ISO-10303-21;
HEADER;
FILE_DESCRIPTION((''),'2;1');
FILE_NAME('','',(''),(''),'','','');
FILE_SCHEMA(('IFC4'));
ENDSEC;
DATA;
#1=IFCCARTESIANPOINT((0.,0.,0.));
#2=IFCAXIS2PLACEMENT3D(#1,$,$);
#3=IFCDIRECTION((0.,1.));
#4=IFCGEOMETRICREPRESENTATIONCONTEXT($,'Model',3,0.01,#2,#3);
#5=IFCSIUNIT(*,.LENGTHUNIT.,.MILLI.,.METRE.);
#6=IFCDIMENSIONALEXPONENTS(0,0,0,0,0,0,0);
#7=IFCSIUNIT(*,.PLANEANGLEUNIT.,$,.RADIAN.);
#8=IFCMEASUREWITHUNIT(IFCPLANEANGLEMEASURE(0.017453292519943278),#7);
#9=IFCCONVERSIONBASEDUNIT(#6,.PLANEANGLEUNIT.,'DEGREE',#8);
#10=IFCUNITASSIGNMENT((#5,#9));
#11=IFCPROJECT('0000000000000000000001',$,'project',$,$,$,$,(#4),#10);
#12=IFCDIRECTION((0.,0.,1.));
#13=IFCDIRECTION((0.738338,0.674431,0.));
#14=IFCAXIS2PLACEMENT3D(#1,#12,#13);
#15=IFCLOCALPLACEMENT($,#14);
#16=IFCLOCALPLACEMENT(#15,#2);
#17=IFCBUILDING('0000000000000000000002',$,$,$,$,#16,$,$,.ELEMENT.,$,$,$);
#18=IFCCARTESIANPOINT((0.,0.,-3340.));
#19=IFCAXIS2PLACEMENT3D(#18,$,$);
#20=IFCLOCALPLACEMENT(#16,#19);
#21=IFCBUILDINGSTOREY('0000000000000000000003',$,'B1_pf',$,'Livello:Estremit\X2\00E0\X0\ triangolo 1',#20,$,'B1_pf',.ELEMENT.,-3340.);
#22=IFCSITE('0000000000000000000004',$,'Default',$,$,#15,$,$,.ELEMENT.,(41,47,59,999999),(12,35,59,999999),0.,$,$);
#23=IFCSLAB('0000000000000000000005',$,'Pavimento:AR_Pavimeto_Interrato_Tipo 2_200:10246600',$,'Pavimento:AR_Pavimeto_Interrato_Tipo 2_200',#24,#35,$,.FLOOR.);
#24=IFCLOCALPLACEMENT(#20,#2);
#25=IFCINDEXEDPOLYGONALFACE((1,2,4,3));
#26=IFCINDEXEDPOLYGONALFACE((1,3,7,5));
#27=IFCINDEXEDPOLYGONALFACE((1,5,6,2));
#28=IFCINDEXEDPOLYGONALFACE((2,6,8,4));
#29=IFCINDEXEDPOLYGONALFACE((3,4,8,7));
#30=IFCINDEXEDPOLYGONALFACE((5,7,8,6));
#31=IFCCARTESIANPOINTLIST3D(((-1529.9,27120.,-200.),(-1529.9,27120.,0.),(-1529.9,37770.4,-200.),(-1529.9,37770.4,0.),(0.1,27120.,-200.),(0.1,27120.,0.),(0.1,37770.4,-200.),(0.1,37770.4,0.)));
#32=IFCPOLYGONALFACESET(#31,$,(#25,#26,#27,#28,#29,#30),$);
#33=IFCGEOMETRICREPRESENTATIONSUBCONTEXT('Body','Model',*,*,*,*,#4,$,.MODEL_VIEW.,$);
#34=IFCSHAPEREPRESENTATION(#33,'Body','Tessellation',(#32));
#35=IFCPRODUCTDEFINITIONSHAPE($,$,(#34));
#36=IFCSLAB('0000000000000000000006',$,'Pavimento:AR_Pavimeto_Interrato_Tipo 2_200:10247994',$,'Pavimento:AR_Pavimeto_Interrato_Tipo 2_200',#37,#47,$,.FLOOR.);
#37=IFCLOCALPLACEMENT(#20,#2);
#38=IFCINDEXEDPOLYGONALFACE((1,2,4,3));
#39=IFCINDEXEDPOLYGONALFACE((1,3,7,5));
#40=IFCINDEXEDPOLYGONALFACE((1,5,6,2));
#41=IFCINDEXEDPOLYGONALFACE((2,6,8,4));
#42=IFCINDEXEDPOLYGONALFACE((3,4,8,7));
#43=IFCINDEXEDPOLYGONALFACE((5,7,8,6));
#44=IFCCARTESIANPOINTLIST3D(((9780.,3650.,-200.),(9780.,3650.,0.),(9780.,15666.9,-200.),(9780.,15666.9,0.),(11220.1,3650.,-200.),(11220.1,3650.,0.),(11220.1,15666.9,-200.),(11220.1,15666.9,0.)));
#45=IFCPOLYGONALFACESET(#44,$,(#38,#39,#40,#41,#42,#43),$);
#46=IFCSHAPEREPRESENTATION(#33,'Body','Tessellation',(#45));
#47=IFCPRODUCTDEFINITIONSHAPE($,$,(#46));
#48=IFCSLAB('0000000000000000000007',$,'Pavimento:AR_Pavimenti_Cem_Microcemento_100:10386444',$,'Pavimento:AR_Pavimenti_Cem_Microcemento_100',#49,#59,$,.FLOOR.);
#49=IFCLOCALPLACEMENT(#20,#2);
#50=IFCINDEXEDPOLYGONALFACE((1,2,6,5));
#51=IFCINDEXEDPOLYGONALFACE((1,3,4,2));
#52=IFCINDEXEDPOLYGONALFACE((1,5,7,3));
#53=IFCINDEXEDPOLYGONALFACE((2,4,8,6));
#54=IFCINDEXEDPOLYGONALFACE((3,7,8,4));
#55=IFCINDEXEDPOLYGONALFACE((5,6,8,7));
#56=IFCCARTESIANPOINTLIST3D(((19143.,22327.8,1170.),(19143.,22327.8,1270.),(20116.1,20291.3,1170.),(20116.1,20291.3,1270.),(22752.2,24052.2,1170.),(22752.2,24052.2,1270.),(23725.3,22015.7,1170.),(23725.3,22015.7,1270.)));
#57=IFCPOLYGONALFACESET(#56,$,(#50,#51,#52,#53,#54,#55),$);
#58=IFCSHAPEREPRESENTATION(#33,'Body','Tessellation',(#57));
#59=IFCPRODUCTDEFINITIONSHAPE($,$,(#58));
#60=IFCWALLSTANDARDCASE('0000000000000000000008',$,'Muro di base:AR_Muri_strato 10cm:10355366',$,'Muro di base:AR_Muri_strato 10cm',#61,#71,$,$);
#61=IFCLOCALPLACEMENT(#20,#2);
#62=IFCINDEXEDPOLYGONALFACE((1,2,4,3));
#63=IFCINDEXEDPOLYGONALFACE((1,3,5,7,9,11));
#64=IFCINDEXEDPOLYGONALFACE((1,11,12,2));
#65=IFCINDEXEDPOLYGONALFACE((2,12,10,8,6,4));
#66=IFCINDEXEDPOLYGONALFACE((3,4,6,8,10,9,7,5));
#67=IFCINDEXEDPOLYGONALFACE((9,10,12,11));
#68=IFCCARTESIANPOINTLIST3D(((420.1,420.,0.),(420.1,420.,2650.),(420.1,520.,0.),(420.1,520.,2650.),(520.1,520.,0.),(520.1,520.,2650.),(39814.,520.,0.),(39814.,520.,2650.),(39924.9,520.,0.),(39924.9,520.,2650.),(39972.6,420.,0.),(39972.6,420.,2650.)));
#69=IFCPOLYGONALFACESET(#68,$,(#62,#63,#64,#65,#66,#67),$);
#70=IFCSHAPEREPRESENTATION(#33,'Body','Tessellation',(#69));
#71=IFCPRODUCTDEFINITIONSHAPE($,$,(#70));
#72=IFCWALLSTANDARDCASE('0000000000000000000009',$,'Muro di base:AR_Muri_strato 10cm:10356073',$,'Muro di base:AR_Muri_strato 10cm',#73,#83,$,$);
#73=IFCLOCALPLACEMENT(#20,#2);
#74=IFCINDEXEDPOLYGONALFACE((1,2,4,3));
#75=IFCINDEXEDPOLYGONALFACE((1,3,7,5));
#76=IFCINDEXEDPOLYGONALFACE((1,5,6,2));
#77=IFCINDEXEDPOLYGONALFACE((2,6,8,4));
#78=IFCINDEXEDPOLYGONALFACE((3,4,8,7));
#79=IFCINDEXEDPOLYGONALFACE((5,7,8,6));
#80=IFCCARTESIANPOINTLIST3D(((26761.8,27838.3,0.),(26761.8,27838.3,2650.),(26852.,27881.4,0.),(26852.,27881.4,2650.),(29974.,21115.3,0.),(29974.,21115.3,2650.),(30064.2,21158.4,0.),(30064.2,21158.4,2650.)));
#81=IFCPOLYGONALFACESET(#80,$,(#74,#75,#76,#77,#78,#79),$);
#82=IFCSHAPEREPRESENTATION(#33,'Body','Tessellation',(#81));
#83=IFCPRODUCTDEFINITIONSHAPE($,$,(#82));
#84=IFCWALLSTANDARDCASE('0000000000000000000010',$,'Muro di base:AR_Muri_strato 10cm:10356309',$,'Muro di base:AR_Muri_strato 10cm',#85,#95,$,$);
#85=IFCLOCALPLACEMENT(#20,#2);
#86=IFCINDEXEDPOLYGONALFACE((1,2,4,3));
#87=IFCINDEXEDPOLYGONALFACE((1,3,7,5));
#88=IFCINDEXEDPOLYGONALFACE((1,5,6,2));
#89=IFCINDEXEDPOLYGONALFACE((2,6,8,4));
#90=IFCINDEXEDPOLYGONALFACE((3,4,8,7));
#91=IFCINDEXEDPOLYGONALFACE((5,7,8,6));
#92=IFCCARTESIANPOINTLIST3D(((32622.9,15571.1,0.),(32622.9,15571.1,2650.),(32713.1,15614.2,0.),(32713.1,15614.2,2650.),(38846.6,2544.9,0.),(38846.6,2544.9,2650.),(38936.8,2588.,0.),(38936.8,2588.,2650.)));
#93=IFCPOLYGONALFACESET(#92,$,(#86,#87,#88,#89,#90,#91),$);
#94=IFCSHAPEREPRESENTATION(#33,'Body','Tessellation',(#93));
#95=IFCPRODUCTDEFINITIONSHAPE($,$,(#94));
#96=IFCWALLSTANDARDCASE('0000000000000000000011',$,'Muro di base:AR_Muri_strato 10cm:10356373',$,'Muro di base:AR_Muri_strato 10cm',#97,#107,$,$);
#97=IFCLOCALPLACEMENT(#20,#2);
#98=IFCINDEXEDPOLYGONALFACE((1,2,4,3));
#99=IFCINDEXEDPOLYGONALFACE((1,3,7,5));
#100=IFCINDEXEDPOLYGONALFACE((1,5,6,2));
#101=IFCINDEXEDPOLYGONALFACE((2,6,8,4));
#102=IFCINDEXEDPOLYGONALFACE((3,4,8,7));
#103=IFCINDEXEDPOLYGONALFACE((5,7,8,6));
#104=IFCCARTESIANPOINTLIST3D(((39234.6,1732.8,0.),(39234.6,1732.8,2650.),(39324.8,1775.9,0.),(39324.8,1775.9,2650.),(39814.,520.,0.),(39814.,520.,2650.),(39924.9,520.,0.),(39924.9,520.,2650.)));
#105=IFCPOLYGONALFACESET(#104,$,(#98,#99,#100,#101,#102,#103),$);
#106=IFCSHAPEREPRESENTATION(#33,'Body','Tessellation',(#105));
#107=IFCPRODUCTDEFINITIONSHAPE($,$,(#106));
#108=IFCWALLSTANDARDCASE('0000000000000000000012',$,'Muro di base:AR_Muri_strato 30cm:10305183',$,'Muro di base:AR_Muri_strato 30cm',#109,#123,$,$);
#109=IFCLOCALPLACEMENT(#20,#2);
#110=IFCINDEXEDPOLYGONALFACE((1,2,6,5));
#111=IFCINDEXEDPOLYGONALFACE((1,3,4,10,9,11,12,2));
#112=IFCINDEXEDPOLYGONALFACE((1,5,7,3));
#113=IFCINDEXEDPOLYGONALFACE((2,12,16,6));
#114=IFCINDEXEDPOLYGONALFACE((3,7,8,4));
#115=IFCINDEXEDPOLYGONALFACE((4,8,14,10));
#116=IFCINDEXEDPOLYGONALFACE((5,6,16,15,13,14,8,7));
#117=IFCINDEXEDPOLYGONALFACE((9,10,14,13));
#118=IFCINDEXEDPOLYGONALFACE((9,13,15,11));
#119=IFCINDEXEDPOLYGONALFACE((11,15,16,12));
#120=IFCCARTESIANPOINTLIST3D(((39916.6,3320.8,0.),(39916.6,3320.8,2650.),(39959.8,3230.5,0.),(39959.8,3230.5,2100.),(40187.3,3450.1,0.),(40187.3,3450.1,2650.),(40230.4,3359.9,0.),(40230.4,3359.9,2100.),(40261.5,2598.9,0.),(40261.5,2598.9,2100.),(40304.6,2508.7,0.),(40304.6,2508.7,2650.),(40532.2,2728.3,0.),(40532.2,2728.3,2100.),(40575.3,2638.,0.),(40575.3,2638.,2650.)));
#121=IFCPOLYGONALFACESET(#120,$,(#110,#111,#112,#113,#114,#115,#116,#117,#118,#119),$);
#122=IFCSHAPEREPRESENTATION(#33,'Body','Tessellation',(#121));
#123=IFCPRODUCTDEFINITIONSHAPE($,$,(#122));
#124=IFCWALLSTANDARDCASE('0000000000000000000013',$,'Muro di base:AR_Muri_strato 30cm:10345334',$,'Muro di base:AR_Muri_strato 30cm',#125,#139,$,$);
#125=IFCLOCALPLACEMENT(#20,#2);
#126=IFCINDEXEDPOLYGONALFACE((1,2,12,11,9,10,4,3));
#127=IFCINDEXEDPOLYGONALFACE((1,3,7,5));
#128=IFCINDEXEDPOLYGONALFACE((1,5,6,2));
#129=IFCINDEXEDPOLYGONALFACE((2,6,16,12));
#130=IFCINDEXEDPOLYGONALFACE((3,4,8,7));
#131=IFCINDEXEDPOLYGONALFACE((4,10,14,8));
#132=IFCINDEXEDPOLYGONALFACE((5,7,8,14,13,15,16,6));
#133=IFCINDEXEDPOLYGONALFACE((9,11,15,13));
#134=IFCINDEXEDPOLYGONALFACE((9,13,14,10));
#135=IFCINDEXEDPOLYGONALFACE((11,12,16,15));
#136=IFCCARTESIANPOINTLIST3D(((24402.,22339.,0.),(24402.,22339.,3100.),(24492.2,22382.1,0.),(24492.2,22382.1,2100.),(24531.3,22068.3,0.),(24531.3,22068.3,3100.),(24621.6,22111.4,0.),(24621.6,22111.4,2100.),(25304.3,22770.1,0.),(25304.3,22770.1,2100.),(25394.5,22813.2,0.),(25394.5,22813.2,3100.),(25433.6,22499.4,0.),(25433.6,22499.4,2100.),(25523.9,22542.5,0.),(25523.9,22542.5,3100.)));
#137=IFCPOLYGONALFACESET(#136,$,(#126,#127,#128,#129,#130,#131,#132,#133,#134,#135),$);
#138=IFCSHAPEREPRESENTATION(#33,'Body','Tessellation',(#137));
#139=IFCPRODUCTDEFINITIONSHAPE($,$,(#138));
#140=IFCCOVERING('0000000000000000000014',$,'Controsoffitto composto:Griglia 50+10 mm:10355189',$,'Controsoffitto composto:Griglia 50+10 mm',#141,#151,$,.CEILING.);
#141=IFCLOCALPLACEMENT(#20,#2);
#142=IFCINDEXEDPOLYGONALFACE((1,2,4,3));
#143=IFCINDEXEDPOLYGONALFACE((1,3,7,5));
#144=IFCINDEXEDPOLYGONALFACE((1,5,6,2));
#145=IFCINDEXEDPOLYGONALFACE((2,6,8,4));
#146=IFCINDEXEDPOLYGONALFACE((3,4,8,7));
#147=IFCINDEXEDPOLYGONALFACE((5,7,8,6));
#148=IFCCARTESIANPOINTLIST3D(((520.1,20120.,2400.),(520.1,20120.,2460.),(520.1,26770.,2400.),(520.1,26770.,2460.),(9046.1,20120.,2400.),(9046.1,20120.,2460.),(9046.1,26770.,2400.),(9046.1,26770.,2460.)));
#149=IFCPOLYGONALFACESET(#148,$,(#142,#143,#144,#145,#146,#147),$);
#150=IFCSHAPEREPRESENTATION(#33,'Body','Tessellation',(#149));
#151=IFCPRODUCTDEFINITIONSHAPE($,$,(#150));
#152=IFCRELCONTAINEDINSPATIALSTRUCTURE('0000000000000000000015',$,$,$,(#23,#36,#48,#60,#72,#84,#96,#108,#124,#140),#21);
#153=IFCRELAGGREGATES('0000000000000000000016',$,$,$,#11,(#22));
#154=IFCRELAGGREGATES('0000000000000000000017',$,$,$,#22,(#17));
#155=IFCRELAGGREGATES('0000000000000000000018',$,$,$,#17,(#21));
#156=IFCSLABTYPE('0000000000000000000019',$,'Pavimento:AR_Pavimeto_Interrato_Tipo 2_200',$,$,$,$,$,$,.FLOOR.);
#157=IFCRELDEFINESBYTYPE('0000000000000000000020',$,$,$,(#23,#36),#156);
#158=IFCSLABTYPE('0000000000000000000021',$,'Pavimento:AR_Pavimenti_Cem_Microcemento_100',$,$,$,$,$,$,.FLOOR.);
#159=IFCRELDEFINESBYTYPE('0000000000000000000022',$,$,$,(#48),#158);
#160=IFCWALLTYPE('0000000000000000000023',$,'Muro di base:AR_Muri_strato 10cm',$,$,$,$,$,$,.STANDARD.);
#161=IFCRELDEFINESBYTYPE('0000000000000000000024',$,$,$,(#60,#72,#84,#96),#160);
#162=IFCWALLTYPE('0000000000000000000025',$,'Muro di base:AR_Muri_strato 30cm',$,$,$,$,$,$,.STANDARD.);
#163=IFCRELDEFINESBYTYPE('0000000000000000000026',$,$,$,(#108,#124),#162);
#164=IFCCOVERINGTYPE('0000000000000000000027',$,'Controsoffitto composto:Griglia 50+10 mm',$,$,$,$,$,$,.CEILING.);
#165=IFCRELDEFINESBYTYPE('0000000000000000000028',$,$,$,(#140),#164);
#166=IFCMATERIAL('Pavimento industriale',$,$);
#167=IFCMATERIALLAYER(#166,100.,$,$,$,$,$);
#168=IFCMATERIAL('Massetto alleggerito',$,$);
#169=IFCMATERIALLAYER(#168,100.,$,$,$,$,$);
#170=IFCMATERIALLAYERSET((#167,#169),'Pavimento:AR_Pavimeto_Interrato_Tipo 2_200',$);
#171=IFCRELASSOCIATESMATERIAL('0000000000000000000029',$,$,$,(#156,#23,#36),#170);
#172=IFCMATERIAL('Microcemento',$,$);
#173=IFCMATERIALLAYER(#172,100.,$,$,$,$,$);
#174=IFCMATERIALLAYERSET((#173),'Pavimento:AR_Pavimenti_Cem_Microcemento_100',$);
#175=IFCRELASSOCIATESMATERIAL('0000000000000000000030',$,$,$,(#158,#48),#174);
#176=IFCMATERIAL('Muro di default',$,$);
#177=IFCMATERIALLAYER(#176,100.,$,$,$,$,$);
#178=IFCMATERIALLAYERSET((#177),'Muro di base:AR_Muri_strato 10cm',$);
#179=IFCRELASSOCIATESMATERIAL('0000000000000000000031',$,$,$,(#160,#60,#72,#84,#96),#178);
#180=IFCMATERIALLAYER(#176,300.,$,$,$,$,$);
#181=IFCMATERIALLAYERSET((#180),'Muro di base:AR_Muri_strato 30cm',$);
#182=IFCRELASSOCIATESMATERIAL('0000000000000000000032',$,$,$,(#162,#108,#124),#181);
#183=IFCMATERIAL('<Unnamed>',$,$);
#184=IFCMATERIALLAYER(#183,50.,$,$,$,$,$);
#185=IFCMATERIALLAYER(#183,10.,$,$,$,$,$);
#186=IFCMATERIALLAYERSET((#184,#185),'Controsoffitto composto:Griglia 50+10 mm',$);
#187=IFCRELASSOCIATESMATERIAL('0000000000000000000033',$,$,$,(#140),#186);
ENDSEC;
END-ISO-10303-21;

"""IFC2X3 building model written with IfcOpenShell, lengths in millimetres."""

from ifc_helpers import new_model, entity, si_unit, converted_unit, direction, frame, frame_2d, origin, origin_2d_with_axis, place, context, subcontext, project, spatial, polyline, rectangle, outline, extrude, material, layer, layer_set, layer_usage, type_object, element, save


model = new_model("IFC2X3")

# Units and contexts
model_context = context("Model", 3, precision=0.01, world=origin(), true_north=direction((0.0, 1.0)))
body_context = subcontext(model_context, "Body", "Model", "MODEL_VIEW")
ifc_project = project(units=[si_unit("LENGTHUNIT", "METRE", prefix="MILLI"), converted_unit("PLANEANGLEUNIT", "DEGREE", entity("IfcPlaneAngleMeasure", 0.017453292519943278), si_unit("PLANEANGLEUNIT", "RADIAN"), dimensions=[0, 0, 0, 0, 0, 0, 0])], contexts=[model_context])

# Site, building, storey
site_placement = place(None, frame((0.0, 0.0, 0.0), z_axis=(0.0, 0.0, 1.0), x_axis=(0.738338, 0.674431, 0.0)))
site = spatial("IfcSite", under=ifc_project, at=site_placement, Name="Default", CompositionType="ELEMENT", RefLatitude=(41, 47, 59, 999999), RefLongitude=(12, 35, 59, 999999), RefElevation=0.0)
building_placement = place(site_placement, origin())
building = spatial("IfcBuilding", under=site, at=building_placement, CompositionType="ELEMENT")
storey_placement = place(building_placement, frame((0.0, 0.0, -3340.0)))
storey = spatial("IfcBuildingStorey", under=building, at=storey_placement, Name="B1_pf", ObjectType="Livello:Estremità triangolo 1", LongName="B1_pf", CompositionType="ELEMENT", Elevation=-3340.0)

# Slabs
ifc_material_1 = material(Name="Pavimento industriale")
ifc_layer_1 = layer(ifc_material_1, 100.0)
ifc_material_2 = material(Name="Massetto alleggerito")
ifc_layer_2 = layer(ifc_material_2, 100.0)
ifc_layer_set_1 = layer_set([ifc_layer_1, ifc_layer_2], Name="Pavimento:AR_Pavimeto_Interrato_Tipo 2_200")
slab_type_1 = type_object("IfcSlabType", Name="Pavimento:AR_Pavimeto_Interrato_Tipo 2_200", PredefinedType="FLOOR", material=ifc_layer_set_1)
ifc_layer_usage_1 = layer_usage(ifc_layer_set_1, "AXIS3", "POSITIVE", 0.0)
slab_1_placement = place(storey_placement, origin())
element("IfcSlab", 1, at=slab_1_placement, inside=storey, type_object=slab_type_1, material=ifc_layer_usage_1, Name="Pavimento:AR_Pavimeto_Interrato_Tipo 2_200:10246600", ObjectType="Pavimento:AR_Pavimeto_Interrato_Tipo 2_200", PredefinedType="FLOOR", context=body_context, shape_type="SweptSolid", body=[
    extrude(rectangle(XDim=10650.3, YDim=1530.0, at=origin_2d_with_axis()), frame((-764.9, 32445.2, 0.0), z_axis=(0.0, 0.0, -1.0), x_axis=(0.0, 1.0, 0.0)), (0.0, 0.0, 1.0), 200.0),
])
ifc_layer_usage_2 = layer_usage(ifc_layer_set_1, "AXIS3", "POSITIVE", 0.0)
slab_2_placement = place(storey_placement, origin())
element("IfcSlab", 2, at=slab_2_placement, inside=storey, type_object=slab_type_1, material=ifc_layer_usage_2, Name="Pavimento:AR_Pavimeto_Interrato_Tipo 2_200:10247994", ObjectType="Pavimento:AR_Pavimeto_Interrato_Tipo 2_200", PredefinedType="FLOOR", context=body_context, shape_type="SweptSolid", body=[
    extrude(rectangle(XDim=12016.9, YDim=1440.0, at=frame_2d((0.0, 0.0), x_axis=(1.0, 0.0))), frame((10500.1, 9658.5, 0.0), z_axis=(0.0, 0.0, -1.0), x_axis=(0.0, 1.0, 0.0)), (0.0, 0.0, 1.0), 200.0),
])
ifc_material_3 = material(Name="Microcemento")
ifc_layer_3 = layer(ifc_material_3, 100.0)
ifc_layer_set_2 = layer_set([ifc_layer_3], Name="Pavimento:AR_Pavimenti_Cem_Microcemento_100")
ifc_layer_usage_3 = layer_usage(ifc_layer_set_2, "AXIS3", "POSITIVE", 0.0)
slab_type_2 = type_object("IfcSlabType", Name="Pavimento:AR_Pavimenti_Cem_Microcemento_100", PredefinedType="FLOOR", material=ifc_layer_set_2)
slab_3_placement = place(storey_placement, origin())
element("IfcSlab", 3, at=slab_3_placement, inside=storey, type_object=slab_type_2, material=ifc_layer_usage_3, Name="Pavimento:AR_Pavimenti_Cem_Microcemento_100:10386444", ObjectType="Pavimento:AR_Pavimenti_Cem_Microcemento_100", PredefinedType="FLOOR", context=body_context, shape_type="SweptSolid", body=[
    extrude(rectangle(XDim=2257.1, YDim=4000.0, at=frame_2d((0.0, 0.0), x_axis=(1.0, 0.0))), frame((21434.1, 22171.8, 1270.0), z_axis=(0.0, 0.0, -1.0), x_axis=(0.431105, -0.902302, 0.0)), (0.0, 0.0, 1.0), 100.0),
])

# Walls
ifc_material_4 = material(Name="Muro di default")
ifc_layer_4 = layer(ifc_material_4, 100.0)
ifc_layer_set_3 = layer_set([ifc_layer_4], Name="Muro di base:AR_Muri_strato 10cm")
ifc_layer_usage_4 = layer_usage(ifc_layer_set_3, "AXIS2", "NEGATIVE", 50.0)
wall_type_1 = type_object("IfcWallType", Name="Muro di base:AR_Muri_strato 10cm", PredefinedType="STANDARD", material=ifc_layer_set_3)
wall_1_placement = place(storey_placement, frame((39972.6, 470.0, 0.0), z_axis=(0.0, 0.0, 1.0), x_axis=(-1.0, 0.0, 0.0)))
element("IfcWallStandardCase", 4, at=wall_1_placement, inside=storey, type_object=wall_type_1, material=ifc_layer_usage_4, Name="Muro di base:AR_Muri_strato 10cm:10355366", ObjectType="Muro di base:AR_Muri_strato 10cm", context=body_context, shape_type="SweptSolid", body=[
    extrude(outline(polyline([(39552.6, -50.0), (39552.6, 50.0), (0.0, 50.0), (47.8, -50.0), (158.6, -50.0), (39452.6, -50.0), (39552.6, -50.0)])), origin(), (0.0, 0.0, 1.0), 2650.0),
])
ifc_layer_usage_5 = layer_usage(ifc_layer_set_3, "AXIS2", "NEGATIVE", 50.0)
wall_2_placement = place(storey_placement, frame((26806.9, 27859.9, 0.0), z_axis=(0.0, 0.0, 1.0), x_axis=(0.431106, -0.902301, 0.0)))
element("IfcWallStandardCase", 5, at=wall_2_placement, inside=storey, type_object=wall_type_1, material=ifc_layer_usage_5, Name="Muro di base:AR_Muri_strato 10cm:10356073", ObjectType="Muro di base:AR_Muri_strato 10cm", context=body_context, shape_type="SweptSolid", body=[
    extrude(rectangle(XDim=7451.0, YDim=100.0, at=frame_2d((3725.5, 0.0), x_axis=(-1.0, 0.0))), origin(), (0.0, 0.0, 1.0), 2650.0),
])
ifc_layer_usage_6 = layer_usage(ifc_layer_set_3, "AXIS2", "NEGATIVE", 50.0)
wall_3_placement = place(storey_placement, frame((32668.0, 15592.6, 0.0), z_axis=(0.0, 0.0, 1.0), x_axis=(0.431105, -0.902302, 0.0)))
element("IfcWallStandardCase", 6, at=wall_3_placement, inside=storey, type_object=wall_type_1, material=ifc_layer_usage_6, Name="Muro di base:AR_Muri_strato 10cm:10356309", ObjectType="Muro di base:AR_Muri_strato 10cm", context=body_context, shape_type="SweptSolid", body=[
    extrude(rectangle(XDim=14436.6, YDim=100.0, at=frame_2d((7218.3, 0.0), x_axis=(-1.0, 0.0))), origin(), (0.0, 0.0, 1.0), 2650.0),
])
ifc_layer_usage_7 = layer_usage(ifc_layer_set_3, "AXIS2", "NEGATIVE", 50.0)
wall_4_placement = place(storey_placement, frame((39279.7, 1754.3, 0.0), z_axis=(0.0, 0.0, 1.0), x_axis=(0.431105, -0.902302, 0.0)))
element("IfcWallStandardCase", 7, at=wall_4_placement, inside=storey, type_object=wall_type_1, material=ifc_layer_usage_7, Name="Muro di base:AR_Muri_strato 10cm:10356373", ObjectType="Muro di base:AR_Muri_strato 10cm", context=body_context, shape_type="SweptSolid", body=[
    extrude(outline(polyline([(1344.1, -50.0), (1391.9, 50.0), (0.0, 50.0), (0.0, -50.0), (1344.1, -50.0)])), origin(), (0.0, 0.0, 1.0), 2650.0),
])

# Walls, openings
ifc_layer_5 = layer(ifc_material_4, 300.0)
ifc_layer_set_4 = layer_set([ifc_layer_5], Name="Muro di base:AR_Muri_strato 30cm")
ifc_layer_usage_8 = layer_usage(ifc_layer_set_4, "AXIS2", "NEGATIVE", 150.0)
wall_type_2 = type_object("IfcWallType", Name="Muro di base:AR_Muri_strato 30cm", PredefinedType="STANDARD", material=ifc_layer_set_4)
wall_5_placement = place(storey_placement, frame((40052.0, 3385.4, 0.0), z_axis=(0.0, 0.0, 1.0), x_axis=(0.431105, -0.902302, 0.0)))
wall_5 = element("IfcWallStandardCase", 8, at=wall_5_placement, inside=storey, type_object=wall_type_2, material=ifc_layer_usage_8, Name="Muro di base:AR_Muri_strato 30cm:10305183", ObjectType="Muro di base:AR_Muri_strato 30cm", context=body_context, shape_type="SweptSolid", body=[
    extrude(rectangle(XDim=900.0, YDim=300.0, at=frame_2d((450.0, 0.0), x_axis=(-1.0, 0.0))), origin(), (0.0, 0.0, 1.0), 2650.0),
])
opening_1_placement = place(wall_5_placement, frame((100.0, -150.0, 0.0)))
element("IfcOpeningElement", 9, at=opening_1_placement, cuts=wall_5, ObjectType="Opening", context=body_context, shape_type="SweptSolid", body=[
    extrude(rectangle(XDim=2100.0, YDim=700.0, at=frame_2d((1050.0, 350.0), x_axis=(1.0, 0.0))), frame((0.0, 0.0, 0.0), z_axis=(0.0, 1.0, 0.0), x_axis=(0.0, 0.0, 1.0)), (0.0, 0.0, 1.0), 300.0),
])
ifc_layer_usage_9 = layer_usage(ifc_layer_set_4, "AXIS2", "NEGATIVE", 150.0)
wall_6_placement = place(storey_placement, frame((24466.7, 22203.7, 0.0), z_axis=(0.0, 0.0, 1.0), x_axis=(0.902302, 0.431105, 0.0)))
wall_6 = element("IfcWallStandardCase", 10, at=wall_6_placement, inside=storey, type_object=wall_type_2, material=ifc_layer_usage_9, Name="Muro di base:AR_Muri_strato 30cm:10345334", ObjectType="Muro di base:AR_Muri_strato 30cm", context=body_context, shape_type="SweptSolid", body=[
    extrude(rectangle(XDim=1100.0, YDim=300.0, at=frame_2d((550.0, 0.0), x_axis=(-1.0, 0.0))), origin(), (0.0, 0.0, 1.0), 3100.0),
])
opening_2_placement = place(wall_6_placement, frame((-31648.4, -9486.7, 0.0), z_axis=(0.0, 0.0, 1.0), x_axis=(0.902302, -0.431105, 0.0)))
element("IfcOpeningElement", 11, at=opening_2_placement, cuts=wall_6, ObjectType="Opening", context=body_context, shape_type="SweptSolid", body=[
    extrude(rectangle(XDim=2100.0, YDim=900.0, at=frame_2d((0.0, 0.0), x_axis=(0.0, 1.0))), frame((25684.6, 20930.3, 1050.0), z_axis=(-0.431105, 0.902302, 0.0), x_axis=(0.902302, 0.431105, 0.0)), (0.0, 0.0, 1.0), 3048.0),
])

# Covering
ifc_material_5 = material(Name="<Unnamed>")
ifc_layer_6 = layer(ifc_material_5, 50.0)
ifc_layer_7 = layer(ifc_material_5, 10.0)
ifc_layer_set_5 = layer_set([ifc_layer_6, ifc_layer_7], Name="Controsoffitto composto:Griglia 50+10 mm")
ifc_layer_usage_10 = layer_usage(ifc_layer_set_5, "AXIS3", "NEGATIVE", 60.0)
covering_type = type_object("IfcCoveringType", Name="Controsoffitto composto:Griglia 50+10 mm", PredefinedType="CEILING")
covering_placement = place(storey_placement, origin())
element("IfcCovering", 12, at=covering_placement, inside=storey, type_object=covering_type, material=ifc_layer_usage_10, Name="Controsoffitto composto:Griglia 50+10 mm:10355189", ObjectType="Controsoffitto composto:Griglia 50+10 mm", PredefinedType="CEILING", context=body_context, shape_type="SweptSolid", body=[
    extrude(rectangle(XDim=8526.0, YDim=6650.0, at=frame_2d((0.0, 0.0), x_axis=(1.0, 0.0))), frame((4783.1, 23445.0, 2400.0), z_axis=(0.0, 0.0, 1.0), x_axis=(-1.0, 0.0, 0.0)), (0.0, 0.0, 1.0), 60.0),
])

save(model, "model.ifc")
